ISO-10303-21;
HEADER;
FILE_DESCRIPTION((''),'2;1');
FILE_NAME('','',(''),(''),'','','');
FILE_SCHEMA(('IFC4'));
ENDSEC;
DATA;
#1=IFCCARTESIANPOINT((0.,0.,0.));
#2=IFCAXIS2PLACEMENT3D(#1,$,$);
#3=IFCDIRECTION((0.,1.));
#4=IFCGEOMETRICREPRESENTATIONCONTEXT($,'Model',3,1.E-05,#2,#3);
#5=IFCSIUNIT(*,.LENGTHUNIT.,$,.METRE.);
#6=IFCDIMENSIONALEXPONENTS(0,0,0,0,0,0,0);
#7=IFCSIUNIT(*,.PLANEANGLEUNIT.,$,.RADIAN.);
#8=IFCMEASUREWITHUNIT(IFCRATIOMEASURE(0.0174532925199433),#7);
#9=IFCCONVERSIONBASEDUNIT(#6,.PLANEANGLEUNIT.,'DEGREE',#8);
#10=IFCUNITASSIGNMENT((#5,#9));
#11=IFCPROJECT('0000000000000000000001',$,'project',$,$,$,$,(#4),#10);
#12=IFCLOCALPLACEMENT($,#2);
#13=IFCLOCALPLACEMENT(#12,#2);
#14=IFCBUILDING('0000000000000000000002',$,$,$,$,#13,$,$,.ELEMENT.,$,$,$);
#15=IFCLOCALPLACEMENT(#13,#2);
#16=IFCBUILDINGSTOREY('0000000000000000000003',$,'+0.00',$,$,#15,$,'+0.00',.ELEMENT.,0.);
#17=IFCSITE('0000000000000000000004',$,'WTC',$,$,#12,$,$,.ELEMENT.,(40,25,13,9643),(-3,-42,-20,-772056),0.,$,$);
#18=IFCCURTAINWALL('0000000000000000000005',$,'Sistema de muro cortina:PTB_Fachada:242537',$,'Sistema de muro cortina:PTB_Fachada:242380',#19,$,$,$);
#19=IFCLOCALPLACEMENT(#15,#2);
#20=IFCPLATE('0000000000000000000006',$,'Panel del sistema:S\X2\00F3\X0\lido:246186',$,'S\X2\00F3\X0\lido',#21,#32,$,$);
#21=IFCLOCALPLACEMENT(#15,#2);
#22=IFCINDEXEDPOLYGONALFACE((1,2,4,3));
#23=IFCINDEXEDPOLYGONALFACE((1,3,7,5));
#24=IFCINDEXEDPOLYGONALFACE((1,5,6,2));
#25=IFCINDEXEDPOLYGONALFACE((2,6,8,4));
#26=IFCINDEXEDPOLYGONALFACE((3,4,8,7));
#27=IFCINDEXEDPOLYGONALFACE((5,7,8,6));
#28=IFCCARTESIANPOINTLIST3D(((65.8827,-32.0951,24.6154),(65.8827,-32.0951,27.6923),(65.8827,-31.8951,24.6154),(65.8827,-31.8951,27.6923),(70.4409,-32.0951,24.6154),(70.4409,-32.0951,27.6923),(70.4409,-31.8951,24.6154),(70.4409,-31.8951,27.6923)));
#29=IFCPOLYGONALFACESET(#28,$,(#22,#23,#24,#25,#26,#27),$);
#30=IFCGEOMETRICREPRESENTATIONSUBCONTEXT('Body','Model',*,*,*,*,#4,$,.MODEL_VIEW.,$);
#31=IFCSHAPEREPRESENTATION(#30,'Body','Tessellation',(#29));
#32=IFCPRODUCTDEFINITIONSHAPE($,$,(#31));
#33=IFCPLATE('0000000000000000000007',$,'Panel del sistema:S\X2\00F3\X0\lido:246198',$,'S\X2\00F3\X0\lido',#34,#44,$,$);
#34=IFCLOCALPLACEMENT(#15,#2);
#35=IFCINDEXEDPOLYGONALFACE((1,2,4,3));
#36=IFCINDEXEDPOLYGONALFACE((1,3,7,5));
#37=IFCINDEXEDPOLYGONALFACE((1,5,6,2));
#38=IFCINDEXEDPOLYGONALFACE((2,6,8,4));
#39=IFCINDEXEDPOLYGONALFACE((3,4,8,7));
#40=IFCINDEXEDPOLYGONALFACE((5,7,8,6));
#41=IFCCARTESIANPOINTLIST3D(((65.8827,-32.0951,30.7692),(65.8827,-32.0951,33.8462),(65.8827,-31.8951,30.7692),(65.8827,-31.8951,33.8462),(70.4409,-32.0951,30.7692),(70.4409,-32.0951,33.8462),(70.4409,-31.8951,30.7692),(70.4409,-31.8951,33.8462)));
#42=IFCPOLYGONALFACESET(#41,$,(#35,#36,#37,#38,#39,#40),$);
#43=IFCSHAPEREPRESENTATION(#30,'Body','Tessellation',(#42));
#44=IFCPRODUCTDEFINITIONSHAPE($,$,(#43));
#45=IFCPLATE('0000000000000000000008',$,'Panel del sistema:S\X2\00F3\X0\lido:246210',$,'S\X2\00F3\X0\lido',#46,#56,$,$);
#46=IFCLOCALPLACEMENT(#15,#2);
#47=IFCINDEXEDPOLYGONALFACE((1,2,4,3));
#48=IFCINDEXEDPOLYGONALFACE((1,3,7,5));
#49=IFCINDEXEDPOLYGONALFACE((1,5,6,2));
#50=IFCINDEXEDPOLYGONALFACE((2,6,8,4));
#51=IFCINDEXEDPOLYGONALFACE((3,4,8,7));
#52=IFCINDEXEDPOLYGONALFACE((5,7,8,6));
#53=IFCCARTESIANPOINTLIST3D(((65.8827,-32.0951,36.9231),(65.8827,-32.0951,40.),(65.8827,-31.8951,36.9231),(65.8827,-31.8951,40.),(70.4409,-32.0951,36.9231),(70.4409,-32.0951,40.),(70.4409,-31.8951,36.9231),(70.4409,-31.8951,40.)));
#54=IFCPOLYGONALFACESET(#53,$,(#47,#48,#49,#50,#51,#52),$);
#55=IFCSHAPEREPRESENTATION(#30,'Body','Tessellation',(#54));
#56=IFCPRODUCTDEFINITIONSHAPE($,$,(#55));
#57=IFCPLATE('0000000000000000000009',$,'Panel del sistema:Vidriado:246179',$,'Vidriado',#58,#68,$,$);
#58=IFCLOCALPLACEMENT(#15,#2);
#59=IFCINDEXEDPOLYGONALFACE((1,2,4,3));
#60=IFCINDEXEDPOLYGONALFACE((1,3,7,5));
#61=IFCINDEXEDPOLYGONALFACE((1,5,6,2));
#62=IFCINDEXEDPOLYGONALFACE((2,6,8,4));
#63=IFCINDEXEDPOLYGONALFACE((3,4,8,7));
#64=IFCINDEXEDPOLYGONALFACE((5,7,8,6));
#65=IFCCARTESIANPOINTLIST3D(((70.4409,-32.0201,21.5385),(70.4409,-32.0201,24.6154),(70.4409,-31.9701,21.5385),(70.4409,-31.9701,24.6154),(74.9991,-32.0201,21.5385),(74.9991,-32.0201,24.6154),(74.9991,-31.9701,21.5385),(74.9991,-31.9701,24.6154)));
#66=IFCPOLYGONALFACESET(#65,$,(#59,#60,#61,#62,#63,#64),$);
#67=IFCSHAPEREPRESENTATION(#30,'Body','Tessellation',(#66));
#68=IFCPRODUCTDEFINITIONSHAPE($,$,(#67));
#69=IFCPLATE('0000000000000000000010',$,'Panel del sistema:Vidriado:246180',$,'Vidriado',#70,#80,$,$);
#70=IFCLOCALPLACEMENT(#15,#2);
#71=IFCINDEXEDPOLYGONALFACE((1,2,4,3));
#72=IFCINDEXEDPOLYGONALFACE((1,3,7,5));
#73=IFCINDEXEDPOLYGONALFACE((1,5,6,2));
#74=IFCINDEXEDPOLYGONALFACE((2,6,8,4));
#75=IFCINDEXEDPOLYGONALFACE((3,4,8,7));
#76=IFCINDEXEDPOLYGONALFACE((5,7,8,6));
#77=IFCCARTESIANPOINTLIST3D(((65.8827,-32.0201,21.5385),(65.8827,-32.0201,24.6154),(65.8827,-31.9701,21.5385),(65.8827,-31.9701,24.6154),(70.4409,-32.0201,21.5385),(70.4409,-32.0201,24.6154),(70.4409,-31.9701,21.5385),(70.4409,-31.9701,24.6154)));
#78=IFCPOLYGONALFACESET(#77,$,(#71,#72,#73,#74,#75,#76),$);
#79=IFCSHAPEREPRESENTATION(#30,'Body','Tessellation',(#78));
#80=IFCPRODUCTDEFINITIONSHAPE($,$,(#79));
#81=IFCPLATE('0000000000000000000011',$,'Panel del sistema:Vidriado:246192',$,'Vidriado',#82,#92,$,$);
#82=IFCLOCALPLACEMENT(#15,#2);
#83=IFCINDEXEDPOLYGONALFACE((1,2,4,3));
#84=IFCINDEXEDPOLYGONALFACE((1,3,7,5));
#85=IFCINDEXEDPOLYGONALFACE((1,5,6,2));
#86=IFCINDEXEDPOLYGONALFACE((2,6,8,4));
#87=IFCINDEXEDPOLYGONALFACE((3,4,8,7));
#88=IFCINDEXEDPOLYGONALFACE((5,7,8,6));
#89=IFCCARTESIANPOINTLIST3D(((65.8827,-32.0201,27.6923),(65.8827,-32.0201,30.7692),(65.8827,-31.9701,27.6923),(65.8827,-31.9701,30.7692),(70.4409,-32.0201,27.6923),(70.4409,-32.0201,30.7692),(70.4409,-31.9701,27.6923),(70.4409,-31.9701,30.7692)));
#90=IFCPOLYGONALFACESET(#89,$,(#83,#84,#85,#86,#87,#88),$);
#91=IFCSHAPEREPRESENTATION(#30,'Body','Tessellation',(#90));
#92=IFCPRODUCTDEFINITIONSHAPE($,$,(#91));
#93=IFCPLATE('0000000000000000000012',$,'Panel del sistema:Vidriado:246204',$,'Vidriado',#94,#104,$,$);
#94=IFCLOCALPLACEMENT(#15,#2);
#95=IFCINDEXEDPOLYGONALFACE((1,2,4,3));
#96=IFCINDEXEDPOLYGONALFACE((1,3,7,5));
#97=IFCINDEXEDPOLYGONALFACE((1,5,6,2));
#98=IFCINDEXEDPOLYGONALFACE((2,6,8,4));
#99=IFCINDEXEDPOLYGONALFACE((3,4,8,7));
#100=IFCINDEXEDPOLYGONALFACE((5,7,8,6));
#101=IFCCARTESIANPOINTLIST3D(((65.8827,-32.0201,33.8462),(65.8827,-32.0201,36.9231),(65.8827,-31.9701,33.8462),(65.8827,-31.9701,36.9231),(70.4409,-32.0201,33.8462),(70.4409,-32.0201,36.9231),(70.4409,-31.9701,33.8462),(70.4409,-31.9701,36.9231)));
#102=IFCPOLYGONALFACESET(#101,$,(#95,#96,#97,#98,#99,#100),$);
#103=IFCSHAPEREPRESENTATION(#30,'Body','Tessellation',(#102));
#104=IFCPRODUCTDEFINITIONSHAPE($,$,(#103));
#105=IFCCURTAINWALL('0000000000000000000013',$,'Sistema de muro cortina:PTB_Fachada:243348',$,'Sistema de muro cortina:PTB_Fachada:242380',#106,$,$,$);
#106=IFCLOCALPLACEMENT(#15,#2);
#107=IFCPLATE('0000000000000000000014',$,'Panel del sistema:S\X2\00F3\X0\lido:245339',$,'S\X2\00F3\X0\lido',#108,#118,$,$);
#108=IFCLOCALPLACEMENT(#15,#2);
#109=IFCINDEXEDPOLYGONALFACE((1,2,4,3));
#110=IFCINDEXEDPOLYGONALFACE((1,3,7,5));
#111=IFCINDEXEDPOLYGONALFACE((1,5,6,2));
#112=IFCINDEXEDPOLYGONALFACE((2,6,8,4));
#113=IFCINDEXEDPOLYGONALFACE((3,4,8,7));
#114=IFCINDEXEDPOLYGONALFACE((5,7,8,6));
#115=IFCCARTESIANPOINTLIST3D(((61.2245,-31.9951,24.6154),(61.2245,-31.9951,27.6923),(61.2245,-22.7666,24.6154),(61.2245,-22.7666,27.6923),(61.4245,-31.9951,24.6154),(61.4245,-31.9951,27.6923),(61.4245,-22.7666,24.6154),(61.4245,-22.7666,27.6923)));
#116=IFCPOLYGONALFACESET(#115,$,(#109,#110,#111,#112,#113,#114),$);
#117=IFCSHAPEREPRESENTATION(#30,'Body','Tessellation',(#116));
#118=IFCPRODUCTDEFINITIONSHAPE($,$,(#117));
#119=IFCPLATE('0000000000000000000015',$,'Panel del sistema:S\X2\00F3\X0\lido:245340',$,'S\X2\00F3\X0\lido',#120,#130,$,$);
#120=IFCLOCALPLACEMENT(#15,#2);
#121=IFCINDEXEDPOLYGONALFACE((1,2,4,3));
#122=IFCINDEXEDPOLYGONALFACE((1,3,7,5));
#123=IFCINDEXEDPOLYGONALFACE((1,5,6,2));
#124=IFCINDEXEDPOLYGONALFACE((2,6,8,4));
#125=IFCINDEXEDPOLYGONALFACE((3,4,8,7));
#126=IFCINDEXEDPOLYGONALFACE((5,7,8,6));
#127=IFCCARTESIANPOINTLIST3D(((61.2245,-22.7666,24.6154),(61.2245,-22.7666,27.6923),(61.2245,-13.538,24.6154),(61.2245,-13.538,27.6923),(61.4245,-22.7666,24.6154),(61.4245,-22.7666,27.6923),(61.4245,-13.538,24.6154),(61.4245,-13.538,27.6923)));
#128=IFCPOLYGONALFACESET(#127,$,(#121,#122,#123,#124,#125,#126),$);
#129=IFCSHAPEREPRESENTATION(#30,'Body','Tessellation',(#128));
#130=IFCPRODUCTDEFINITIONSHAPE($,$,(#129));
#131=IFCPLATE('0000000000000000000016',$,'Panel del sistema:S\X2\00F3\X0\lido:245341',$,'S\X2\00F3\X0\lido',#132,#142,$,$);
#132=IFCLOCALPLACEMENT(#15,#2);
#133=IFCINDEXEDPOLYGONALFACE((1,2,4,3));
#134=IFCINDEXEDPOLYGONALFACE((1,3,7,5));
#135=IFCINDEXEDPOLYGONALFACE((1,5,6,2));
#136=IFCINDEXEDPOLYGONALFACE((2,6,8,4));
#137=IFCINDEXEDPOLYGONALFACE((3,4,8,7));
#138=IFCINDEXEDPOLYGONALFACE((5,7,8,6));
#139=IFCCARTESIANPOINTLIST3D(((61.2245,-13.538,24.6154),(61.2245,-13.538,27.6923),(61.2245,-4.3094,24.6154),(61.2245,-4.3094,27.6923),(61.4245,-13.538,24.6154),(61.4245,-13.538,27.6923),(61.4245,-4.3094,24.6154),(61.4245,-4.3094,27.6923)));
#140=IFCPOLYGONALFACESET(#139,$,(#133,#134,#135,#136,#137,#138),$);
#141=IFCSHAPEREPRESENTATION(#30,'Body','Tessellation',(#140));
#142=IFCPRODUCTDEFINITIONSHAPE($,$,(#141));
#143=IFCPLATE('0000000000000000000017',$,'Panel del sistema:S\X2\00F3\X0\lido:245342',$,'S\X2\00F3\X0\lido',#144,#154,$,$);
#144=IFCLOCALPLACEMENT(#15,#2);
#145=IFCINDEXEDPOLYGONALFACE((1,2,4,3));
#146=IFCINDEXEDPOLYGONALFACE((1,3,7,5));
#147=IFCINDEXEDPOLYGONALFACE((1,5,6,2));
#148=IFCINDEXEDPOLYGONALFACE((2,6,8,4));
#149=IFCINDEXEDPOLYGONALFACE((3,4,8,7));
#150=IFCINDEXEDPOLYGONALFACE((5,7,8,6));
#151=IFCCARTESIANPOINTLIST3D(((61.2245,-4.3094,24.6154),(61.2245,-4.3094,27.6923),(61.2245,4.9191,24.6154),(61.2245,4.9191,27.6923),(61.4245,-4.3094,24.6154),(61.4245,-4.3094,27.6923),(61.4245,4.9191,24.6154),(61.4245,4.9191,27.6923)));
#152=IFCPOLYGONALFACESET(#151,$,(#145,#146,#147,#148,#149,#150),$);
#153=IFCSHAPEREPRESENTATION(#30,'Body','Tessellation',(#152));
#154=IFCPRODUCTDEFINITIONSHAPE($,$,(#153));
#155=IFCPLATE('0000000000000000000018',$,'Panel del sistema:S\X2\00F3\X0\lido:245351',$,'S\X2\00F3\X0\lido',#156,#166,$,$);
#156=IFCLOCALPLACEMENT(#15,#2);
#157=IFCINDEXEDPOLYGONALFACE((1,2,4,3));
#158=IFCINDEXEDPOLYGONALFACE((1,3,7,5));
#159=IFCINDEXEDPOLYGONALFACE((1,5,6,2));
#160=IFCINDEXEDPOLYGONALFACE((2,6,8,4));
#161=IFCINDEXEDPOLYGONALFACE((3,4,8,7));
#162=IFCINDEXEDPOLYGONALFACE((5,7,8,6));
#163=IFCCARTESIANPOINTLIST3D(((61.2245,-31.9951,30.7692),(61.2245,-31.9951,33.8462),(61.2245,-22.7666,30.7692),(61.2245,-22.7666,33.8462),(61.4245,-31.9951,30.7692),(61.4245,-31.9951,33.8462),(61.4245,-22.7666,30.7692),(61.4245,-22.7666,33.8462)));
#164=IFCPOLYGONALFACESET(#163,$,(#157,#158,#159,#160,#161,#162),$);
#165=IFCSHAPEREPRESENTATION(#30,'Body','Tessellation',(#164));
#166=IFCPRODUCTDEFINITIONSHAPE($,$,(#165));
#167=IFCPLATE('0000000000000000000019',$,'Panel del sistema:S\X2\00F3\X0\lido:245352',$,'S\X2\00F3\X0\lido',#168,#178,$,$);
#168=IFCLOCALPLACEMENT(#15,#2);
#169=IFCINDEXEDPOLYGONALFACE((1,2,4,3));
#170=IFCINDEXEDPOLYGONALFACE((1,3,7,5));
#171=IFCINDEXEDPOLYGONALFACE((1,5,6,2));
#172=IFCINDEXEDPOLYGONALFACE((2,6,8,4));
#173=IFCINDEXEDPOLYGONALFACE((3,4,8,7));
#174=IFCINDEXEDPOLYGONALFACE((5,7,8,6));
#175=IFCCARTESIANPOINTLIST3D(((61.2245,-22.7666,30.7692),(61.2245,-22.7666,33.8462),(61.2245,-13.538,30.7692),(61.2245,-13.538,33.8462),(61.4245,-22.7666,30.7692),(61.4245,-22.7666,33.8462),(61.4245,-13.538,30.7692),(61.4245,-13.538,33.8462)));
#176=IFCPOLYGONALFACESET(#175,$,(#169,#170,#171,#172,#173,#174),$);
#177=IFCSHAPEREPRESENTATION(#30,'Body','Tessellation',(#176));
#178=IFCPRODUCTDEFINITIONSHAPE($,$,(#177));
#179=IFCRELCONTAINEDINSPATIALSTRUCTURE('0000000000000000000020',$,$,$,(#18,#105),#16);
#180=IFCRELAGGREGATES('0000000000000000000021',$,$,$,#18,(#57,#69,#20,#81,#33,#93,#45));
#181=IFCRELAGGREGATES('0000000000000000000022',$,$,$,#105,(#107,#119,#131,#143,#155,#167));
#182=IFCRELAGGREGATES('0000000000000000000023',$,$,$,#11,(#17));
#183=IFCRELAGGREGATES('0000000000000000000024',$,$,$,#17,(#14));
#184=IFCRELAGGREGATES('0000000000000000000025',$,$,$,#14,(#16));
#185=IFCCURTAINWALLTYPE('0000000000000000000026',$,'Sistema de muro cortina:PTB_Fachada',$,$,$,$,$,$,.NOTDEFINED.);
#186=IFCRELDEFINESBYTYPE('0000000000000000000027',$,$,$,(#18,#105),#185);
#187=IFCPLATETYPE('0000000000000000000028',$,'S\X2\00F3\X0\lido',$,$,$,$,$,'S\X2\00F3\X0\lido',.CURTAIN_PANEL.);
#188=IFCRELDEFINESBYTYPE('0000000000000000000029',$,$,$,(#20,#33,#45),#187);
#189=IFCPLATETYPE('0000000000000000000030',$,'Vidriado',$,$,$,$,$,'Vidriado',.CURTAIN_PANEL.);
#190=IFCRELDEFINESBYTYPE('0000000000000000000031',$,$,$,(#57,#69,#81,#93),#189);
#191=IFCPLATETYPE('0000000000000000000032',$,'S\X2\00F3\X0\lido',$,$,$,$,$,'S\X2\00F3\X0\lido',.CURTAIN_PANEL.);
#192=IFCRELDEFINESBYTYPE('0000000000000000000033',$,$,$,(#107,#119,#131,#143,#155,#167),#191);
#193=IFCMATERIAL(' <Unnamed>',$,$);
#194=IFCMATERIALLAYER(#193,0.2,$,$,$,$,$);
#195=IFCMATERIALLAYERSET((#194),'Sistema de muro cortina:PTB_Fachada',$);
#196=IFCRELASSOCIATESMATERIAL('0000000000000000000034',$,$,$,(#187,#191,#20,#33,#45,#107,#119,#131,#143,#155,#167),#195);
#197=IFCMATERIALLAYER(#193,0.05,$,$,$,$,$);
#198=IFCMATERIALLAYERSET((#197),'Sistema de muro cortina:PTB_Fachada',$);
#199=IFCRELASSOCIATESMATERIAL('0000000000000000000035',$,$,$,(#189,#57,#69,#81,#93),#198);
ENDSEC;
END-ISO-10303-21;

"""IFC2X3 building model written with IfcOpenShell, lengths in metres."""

from ifc_helpers import new_model, entity, si_unit, converted_unit, direction, frame, frame_2d, origin, origin_2d_with_axis, place, context, subcontext, project, spatial, rectangle, extrude, source, transform, mapped, material, layer, layer_set, layer_usage, type_object, type_shapes, element, aggregate, save


model = new_model("IFC2X3")

# Units and contexts
model_context = context("Model", 3, precision=1e-05, world=origin(), true_north=direction((0.0, 1.0)))
body_context = subcontext(model_context, "Body", "Model", "MODEL_VIEW")
ifc_project = project(units=[si_unit("LENGTHUNIT", "METRE"), converted_unit("PLANEANGLEUNIT", "DEGREE", entity("IfcRatioMeasure", 0.0174532925199433), si_unit("PLANEANGLEUNIT", "RADIAN"), dimensions=[0, 0, 0, 0, 0, 0, 0])], contexts=[model_context])

# Site, building, storey
site_placement = place(None, origin())
site = spatial("IfcSite", under=ifc_project, at=site_placement, Name="WTC", CompositionType="ELEMENT", RefLatitude=(40, 25, 13, 9643), RefLongitude=(-3, -42, -20, -772056), RefElevation=0.0)
building_placement = place(site_placement, origin())
building = spatial("IfcBuilding", under=site, at=building_placement, CompositionType="ELEMENT")
storey_placement = place(building_placement, origin())
storey = spatial("IfcBuildingStorey", under=building, at=storey_placement, Name="+0.00", LongName="+0.00", CompositionType="ELEMENT", Elevation=0.0)

# Curtain walls, plates
curtain_wall_type = type_object("IfcCurtainWallType", Name="Sistema de muro cortina:PTB_Fachada", PredefinedType="NOTDEFINED")
curtain_wall_1_placement = place(storey_placement, origin())
curtain_wall_1 = element("IfcCurtainWall", 1, at=curtain_wall_1_placement, inside=storey, type_object=curtain_wall_type, Name="Sistema de muro cortina:PTB_Fachada:242537", ObjectType="Sistema de muro cortina:PTB_Fachada:242380")
ifc_material_1 = material(Name=" <Unnamed>")
ifc_layer_1 = layer(ifc_material_1, 0.2)
ifc_layer_set_1 = layer_set([ifc_layer_1], Name="Sistema de muro cortina:PTB_Fachada")
ifc_layer_usage_1 = layer_usage(ifc_layer_set_1, "AXIS3", "POSITIVE", 0.0)
plate_type_1 = type_object("IfcPlateType", Name="Sólido", ElementType="Sólido", PredefinedType="CURTAIN_PANEL", material=ifc_layer_set_1)
shared_shape_1 = source(origin(), body_context, "Body", "SweptSolid", [
    extrude(rectangle(XDim=0.2, YDim=4.5582, at=origin_2d_with_axis()), frame((0.0, 0.0, 0.0), z_axis=(0.0, 0.0, 1.0), x_axis=(0.0, 1.0, 0.0)), (0.0, 0.0, 1.0), 3.0769),
])
type_shapes(plate_type_1, [shared_shape_1])
plate_1_placement = place(curtain_wall_1_placement, frame((68.1618, -31.9951, 24.6154), z_axis=(0.0, 0.0, 1.0), x_axis=(-1.0, 0.0, 0.0)))
plate_1 = element("IfcPlate", 2, at=plate_1_placement, type_object=plate_type_1, material=ifc_layer_usage_1, Name="Panel del sistema:Sólido:246186", ObjectType="Sólido", context=body_context, shape_type="MappedRepresentation", body=[
    mapped(shared_shape_1, transform((0.0, 0.0, 0.0), scale=1.0)),
])
ifc_layer_usage_2 = layer_usage(ifc_layer_set_1, "AXIS3", "POSITIVE", 0.0)
plate_2_placement = place(curtain_wall_1_placement, frame((68.1618, -31.9951, 30.7692), z_axis=(0.0, 0.0, 1.0), x_axis=(-1.0, 0.0, 0.0)))
plate_2 = element("IfcPlate", 3, at=plate_2_placement, type_object=plate_type_1, material=ifc_layer_usage_2, Name="Panel del sistema:Sólido:246198", ObjectType="Sólido", context=body_context, shape_type="MappedRepresentation", body=[
    mapped(shared_shape_1, transform((0.0, 0.0, 0.0), scale=1.0)),
])
ifc_layer_usage_3 = layer_usage(ifc_layer_set_1, "AXIS3", "POSITIVE", 0.0)
plate_3_placement = place(curtain_wall_1_placement, frame((68.1618, -31.9951, 36.9231), z_axis=(0.0, 0.0, 1.0), x_axis=(-1.0, 0.0, 0.0)))
plate_3 = element("IfcPlate", 4, at=plate_3_placement, type_object=plate_type_1, material=ifc_layer_usage_3, Name="Panel del sistema:Sólido:246210", ObjectType="Sólido", context=body_context, shape_type="MappedRepresentation", body=[
    mapped(shared_shape_1, transform((0.0, 0.0, 0.0), scale=1.0)),
])
ifc_layer_2 = layer(ifc_material_1, 0.05)
ifc_layer_set_2 = layer_set([ifc_layer_2], Name="Sistema de muro cortina:PTB_Fachada")
ifc_layer_usage_4 = layer_usage(ifc_layer_set_2, "AXIS3", "POSITIVE", 0.0)
plate_type_2 = type_object("IfcPlateType", Name="Vidriado", ElementType="Vidriado", PredefinedType="CURTAIN_PANEL", material=ifc_layer_set_2)
shared_shape_2 = source(origin(), body_context, "Body", "SweptSolid", [
    extrude(rectangle(XDim=0.05, YDim=4.5582, at=origin_2d_with_axis()), frame((0.0, 0.0, 0.0), z_axis=(0.0, 0.0, 1.0), x_axis=(0.0, 1.0, 0.0)), (0.0, 0.0, 1.0), 3.0769),
])
type_shapes(plate_type_2, [shared_shape_2])
plate_4_placement = place(curtain_wall_1_placement, frame((72.72, -31.9951, 21.5385), z_axis=(0.0, 0.0, 1.0), x_axis=(-1.0, 0.0, 0.0)))
plate_4 = element("IfcPlate", 5, at=plate_4_placement, type_object=plate_type_2, material=ifc_layer_usage_4, Name="Panel del sistema:Vidriado:246179", ObjectType="Vidriado", context=body_context, shape_type="MappedRepresentation", body=[
    mapped(shared_shape_2, transform((0.0, 0.0, 0.0), scale=1.0)),
])
ifc_layer_usage_5 = layer_usage(ifc_layer_set_2, "AXIS3", "POSITIVE", 0.0)
plate_5_placement = place(curtain_wall_1_placement, frame((68.1618, -31.9951, 21.5385), z_axis=(0.0, 0.0, 1.0), x_axis=(-1.0, 0.0, 0.0)))
plate_5 = element("IfcPlate", 6, at=plate_5_placement, type_object=plate_type_2, material=ifc_layer_usage_5, Name="Panel del sistema:Vidriado:246180", ObjectType="Vidriado", context=body_context, shape_type="MappedRepresentation", body=[
    mapped(shared_shape_2, transform((0.0, 0.0, 0.0), scale=1.0)),
])
ifc_layer_usage_6 = layer_usage(ifc_layer_set_2, "AXIS3", "POSITIVE", 0.0)
plate_6_placement = place(curtain_wall_1_placement, frame((68.1618, -31.9951, 27.6923), z_axis=(0.0, 0.0, 1.0), x_axis=(-1.0, 0.0, 0.0)))
plate_6 = element("IfcPlate", 7, at=plate_6_placement, type_object=plate_type_2, material=ifc_layer_usage_6, Name="Panel del sistema:Vidriado:246192", ObjectType="Vidriado", context=body_context, shape_type="MappedRepresentation", body=[
    mapped(shared_shape_2, transform((0.0, 0.0, 0.0), scale=1.0)),
])
ifc_layer_usage_7 = layer_usage(ifc_layer_set_2, "AXIS3", "POSITIVE", 0.0)
plate_7_placement = place(curtain_wall_1_placement, frame((68.1618, -31.9951, 33.8462), z_axis=(0.0, 0.0, 1.0), x_axis=(-1.0, 0.0, 0.0)))
plate_7 = element("IfcPlate", 8, at=plate_7_placement, type_object=plate_type_2, material=ifc_layer_usage_7, Name="Panel del sistema:Vidriado:246204", ObjectType="Vidriado", context=body_context, shape_type="MappedRepresentation", body=[
    mapped(shared_shape_2, transform((0.0, 0.0, 0.0), scale=1.0)),
])
aggregate(curtain_wall_1, [plate_4, plate_5, plate_1, plate_6, plate_2, plate_7, plate_3])
curtain_wall_2_placement = place(storey_placement, origin())
curtain_wall_2 = element("IfcCurtainWall", 9, at=curtain_wall_2_placement, inside=storey, type_object=curtain_wall_type, Name="Sistema de muro cortina:PTB_Fachada:243348", ObjectType="Sistema de muro cortina:PTB_Fachada:242380")
ifc_layer_usage_8 = layer_usage(ifc_layer_set_1, "AXIS3", "POSITIVE", 0.0)
plate_type_3 = type_object("IfcPlateType", Name="Sólido", ElementType="Sólido", PredefinedType="CURTAIN_PANEL", material=ifc_layer_set_1)
shared_shape_3 = source(origin(), body_context, "Body", "SweptSolid", [
    extrude(rectangle(XDim=0.2, YDim=9.2286, at=frame_2d((0.0, 0.0), x_axis=(1.0, 0.0))), frame((0.0, 0.0, 0.0), z_axis=(0.0, 0.0, 1.0), x_axis=(0.0, 1.0, 0.0)), (0.0, 0.0, 1.0), 3.0769),
])
type_shapes(plate_type_3, [shared_shape_3])
plate_8_placement = place(curtain_wall_2_placement, frame((61.3245, -27.3809, 24.6154), z_axis=(0.0, 0.0, 1.0), x_axis=(0.0, 1.0, 0.0)))
plate_8 = element("IfcPlate", 10, at=plate_8_placement, type_object=plate_type_3, material=ifc_layer_usage_8, Name="Panel del sistema:Sólido:245339", ObjectType="Sólido", context=body_context, shape_type="MappedRepresentation", body=[
    mapped(shared_shape_3, transform((0.0, 0.0, 0.0), scale=1.0)),
])
ifc_layer_usage_9 = layer_usage(ifc_layer_set_1, "AXIS3", "POSITIVE", 0.0)
plate_9_placement = place(curtain_wall_2_placement, frame((61.3245, -18.1523, 24.6154), z_axis=(0.0, 0.0, 1.0), x_axis=(0.0, 1.0, 0.0)))
plate_9 = element("IfcPlate", 11, at=plate_9_placement, type_object=plate_type_3, material=ifc_layer_usage_9, Name="Panel del sistema:Sólido:245340", ObjectType="Sólido", context=body_context, shape_type="MappedRepresentation", body=[
    mapped(shared_shape_3, transform((0.0, 0.0, 0.0), scale=1.0)),
])
ifc_layer_usage_10 = layer_usage(ifc_layer_set_1, "AXIS3", "POSITIVE", 0.0)
plate_10_placement = place(curtain_wall_2_placement, frame((61.3245, -8.9237, 24.6154), z_axis=(0.0, 0.0, 1.0), x_axis=(0.0, 1.0, 0.0)))
plate_10 = element("IfcPlate", 12, at=plate_10_placement, type_object=plate_type_3, material=ifc_layer_usage_10, Name="Panel del sistema:Sólido:245341", ObjectType="Sólido", context=body_context, shape_type="MappedRepresentation", body=[
    mapped(shared_shape_3, transform((0.0, 0.0, 0.0), scale=1.0)),
])
ifc_layer_usage_11 = layer_usage(ifc_layer_set_1, "AXIS3", "POSITIVE", 0.0)
plate_11_placement = place(curtain_wall_2_placement, frame((61.3245, 0.3049, 24.6154), z_axis=(0.0, 0.0, 1.0), x_axis=(0.0, 1.0, 0.0)))
plate_11 = element("IfcPlate", 13, at=plate_11_placement, type_object=plate_type_3, material=ifc_layer_usage_11, Name="Panel del sistema:Sólido:245342", ObjectType="Sólido", context=body_context, shape_type="MappedRepresentation", body=[
    mapped(shared_shape_3, transform((0.0, 0.0, 0.0), scale=1.0)),
])
ifc_layer_usage_12 = layer_usage(ifc_layer_set_1, "AXIS3", "POSITIVE", 0.0)
plate_12_placement = place(curtain_wall_2_placement, frame((61.3245, -27.3809, 30.7692), z_axis=(0.0, 0.0, 1.0), x_axis=(0.0, 1.0, 0.0)))
plate_12 = element("IfcPlate", 14, at=plate_12_placement, type_object=plate_type_3, material=ifc_layer_usage_12, Name="Panel del sistema:Sólido:245351", ObjectType="Sólido", context=body_context, shape_type="MappedRepresentation", body=[
    mapped(shared_shape_3, transform((0.0, 0.0, 0.0), scale=1.0)),
])
ifc_layer_usage_13 = layer_usage(ifc_layer_set_1, "AXIS3", "POSITIVE", 0.0)
plate_13_placement = place(curtain_wall_2_placement, frame((61.3245, -18.1523, 30.7692), z_axis=(0.0, 0.0, 1.0), x_axis=(0.0, 1.0, 0.0)))
plate_13 = element("IfcPlate", 15, at=plate_13_placement, type_object=plate_type_3, material=ifc_layer_usage_13, Name="Panel del sistema:Sólido:245352", ObjectType="Sólido", context=body_context, shape_type="MappedRepresentation", body=[
    mapped(shared_shape_3, transform((0.0, 0.0, 0.0), scale=1.0)),
])
aggregate(curtain_wall_2, [plate_8, plate_9, plate_10, plate_11, plate_12, plate_13])

save(model, "model.ifc")
